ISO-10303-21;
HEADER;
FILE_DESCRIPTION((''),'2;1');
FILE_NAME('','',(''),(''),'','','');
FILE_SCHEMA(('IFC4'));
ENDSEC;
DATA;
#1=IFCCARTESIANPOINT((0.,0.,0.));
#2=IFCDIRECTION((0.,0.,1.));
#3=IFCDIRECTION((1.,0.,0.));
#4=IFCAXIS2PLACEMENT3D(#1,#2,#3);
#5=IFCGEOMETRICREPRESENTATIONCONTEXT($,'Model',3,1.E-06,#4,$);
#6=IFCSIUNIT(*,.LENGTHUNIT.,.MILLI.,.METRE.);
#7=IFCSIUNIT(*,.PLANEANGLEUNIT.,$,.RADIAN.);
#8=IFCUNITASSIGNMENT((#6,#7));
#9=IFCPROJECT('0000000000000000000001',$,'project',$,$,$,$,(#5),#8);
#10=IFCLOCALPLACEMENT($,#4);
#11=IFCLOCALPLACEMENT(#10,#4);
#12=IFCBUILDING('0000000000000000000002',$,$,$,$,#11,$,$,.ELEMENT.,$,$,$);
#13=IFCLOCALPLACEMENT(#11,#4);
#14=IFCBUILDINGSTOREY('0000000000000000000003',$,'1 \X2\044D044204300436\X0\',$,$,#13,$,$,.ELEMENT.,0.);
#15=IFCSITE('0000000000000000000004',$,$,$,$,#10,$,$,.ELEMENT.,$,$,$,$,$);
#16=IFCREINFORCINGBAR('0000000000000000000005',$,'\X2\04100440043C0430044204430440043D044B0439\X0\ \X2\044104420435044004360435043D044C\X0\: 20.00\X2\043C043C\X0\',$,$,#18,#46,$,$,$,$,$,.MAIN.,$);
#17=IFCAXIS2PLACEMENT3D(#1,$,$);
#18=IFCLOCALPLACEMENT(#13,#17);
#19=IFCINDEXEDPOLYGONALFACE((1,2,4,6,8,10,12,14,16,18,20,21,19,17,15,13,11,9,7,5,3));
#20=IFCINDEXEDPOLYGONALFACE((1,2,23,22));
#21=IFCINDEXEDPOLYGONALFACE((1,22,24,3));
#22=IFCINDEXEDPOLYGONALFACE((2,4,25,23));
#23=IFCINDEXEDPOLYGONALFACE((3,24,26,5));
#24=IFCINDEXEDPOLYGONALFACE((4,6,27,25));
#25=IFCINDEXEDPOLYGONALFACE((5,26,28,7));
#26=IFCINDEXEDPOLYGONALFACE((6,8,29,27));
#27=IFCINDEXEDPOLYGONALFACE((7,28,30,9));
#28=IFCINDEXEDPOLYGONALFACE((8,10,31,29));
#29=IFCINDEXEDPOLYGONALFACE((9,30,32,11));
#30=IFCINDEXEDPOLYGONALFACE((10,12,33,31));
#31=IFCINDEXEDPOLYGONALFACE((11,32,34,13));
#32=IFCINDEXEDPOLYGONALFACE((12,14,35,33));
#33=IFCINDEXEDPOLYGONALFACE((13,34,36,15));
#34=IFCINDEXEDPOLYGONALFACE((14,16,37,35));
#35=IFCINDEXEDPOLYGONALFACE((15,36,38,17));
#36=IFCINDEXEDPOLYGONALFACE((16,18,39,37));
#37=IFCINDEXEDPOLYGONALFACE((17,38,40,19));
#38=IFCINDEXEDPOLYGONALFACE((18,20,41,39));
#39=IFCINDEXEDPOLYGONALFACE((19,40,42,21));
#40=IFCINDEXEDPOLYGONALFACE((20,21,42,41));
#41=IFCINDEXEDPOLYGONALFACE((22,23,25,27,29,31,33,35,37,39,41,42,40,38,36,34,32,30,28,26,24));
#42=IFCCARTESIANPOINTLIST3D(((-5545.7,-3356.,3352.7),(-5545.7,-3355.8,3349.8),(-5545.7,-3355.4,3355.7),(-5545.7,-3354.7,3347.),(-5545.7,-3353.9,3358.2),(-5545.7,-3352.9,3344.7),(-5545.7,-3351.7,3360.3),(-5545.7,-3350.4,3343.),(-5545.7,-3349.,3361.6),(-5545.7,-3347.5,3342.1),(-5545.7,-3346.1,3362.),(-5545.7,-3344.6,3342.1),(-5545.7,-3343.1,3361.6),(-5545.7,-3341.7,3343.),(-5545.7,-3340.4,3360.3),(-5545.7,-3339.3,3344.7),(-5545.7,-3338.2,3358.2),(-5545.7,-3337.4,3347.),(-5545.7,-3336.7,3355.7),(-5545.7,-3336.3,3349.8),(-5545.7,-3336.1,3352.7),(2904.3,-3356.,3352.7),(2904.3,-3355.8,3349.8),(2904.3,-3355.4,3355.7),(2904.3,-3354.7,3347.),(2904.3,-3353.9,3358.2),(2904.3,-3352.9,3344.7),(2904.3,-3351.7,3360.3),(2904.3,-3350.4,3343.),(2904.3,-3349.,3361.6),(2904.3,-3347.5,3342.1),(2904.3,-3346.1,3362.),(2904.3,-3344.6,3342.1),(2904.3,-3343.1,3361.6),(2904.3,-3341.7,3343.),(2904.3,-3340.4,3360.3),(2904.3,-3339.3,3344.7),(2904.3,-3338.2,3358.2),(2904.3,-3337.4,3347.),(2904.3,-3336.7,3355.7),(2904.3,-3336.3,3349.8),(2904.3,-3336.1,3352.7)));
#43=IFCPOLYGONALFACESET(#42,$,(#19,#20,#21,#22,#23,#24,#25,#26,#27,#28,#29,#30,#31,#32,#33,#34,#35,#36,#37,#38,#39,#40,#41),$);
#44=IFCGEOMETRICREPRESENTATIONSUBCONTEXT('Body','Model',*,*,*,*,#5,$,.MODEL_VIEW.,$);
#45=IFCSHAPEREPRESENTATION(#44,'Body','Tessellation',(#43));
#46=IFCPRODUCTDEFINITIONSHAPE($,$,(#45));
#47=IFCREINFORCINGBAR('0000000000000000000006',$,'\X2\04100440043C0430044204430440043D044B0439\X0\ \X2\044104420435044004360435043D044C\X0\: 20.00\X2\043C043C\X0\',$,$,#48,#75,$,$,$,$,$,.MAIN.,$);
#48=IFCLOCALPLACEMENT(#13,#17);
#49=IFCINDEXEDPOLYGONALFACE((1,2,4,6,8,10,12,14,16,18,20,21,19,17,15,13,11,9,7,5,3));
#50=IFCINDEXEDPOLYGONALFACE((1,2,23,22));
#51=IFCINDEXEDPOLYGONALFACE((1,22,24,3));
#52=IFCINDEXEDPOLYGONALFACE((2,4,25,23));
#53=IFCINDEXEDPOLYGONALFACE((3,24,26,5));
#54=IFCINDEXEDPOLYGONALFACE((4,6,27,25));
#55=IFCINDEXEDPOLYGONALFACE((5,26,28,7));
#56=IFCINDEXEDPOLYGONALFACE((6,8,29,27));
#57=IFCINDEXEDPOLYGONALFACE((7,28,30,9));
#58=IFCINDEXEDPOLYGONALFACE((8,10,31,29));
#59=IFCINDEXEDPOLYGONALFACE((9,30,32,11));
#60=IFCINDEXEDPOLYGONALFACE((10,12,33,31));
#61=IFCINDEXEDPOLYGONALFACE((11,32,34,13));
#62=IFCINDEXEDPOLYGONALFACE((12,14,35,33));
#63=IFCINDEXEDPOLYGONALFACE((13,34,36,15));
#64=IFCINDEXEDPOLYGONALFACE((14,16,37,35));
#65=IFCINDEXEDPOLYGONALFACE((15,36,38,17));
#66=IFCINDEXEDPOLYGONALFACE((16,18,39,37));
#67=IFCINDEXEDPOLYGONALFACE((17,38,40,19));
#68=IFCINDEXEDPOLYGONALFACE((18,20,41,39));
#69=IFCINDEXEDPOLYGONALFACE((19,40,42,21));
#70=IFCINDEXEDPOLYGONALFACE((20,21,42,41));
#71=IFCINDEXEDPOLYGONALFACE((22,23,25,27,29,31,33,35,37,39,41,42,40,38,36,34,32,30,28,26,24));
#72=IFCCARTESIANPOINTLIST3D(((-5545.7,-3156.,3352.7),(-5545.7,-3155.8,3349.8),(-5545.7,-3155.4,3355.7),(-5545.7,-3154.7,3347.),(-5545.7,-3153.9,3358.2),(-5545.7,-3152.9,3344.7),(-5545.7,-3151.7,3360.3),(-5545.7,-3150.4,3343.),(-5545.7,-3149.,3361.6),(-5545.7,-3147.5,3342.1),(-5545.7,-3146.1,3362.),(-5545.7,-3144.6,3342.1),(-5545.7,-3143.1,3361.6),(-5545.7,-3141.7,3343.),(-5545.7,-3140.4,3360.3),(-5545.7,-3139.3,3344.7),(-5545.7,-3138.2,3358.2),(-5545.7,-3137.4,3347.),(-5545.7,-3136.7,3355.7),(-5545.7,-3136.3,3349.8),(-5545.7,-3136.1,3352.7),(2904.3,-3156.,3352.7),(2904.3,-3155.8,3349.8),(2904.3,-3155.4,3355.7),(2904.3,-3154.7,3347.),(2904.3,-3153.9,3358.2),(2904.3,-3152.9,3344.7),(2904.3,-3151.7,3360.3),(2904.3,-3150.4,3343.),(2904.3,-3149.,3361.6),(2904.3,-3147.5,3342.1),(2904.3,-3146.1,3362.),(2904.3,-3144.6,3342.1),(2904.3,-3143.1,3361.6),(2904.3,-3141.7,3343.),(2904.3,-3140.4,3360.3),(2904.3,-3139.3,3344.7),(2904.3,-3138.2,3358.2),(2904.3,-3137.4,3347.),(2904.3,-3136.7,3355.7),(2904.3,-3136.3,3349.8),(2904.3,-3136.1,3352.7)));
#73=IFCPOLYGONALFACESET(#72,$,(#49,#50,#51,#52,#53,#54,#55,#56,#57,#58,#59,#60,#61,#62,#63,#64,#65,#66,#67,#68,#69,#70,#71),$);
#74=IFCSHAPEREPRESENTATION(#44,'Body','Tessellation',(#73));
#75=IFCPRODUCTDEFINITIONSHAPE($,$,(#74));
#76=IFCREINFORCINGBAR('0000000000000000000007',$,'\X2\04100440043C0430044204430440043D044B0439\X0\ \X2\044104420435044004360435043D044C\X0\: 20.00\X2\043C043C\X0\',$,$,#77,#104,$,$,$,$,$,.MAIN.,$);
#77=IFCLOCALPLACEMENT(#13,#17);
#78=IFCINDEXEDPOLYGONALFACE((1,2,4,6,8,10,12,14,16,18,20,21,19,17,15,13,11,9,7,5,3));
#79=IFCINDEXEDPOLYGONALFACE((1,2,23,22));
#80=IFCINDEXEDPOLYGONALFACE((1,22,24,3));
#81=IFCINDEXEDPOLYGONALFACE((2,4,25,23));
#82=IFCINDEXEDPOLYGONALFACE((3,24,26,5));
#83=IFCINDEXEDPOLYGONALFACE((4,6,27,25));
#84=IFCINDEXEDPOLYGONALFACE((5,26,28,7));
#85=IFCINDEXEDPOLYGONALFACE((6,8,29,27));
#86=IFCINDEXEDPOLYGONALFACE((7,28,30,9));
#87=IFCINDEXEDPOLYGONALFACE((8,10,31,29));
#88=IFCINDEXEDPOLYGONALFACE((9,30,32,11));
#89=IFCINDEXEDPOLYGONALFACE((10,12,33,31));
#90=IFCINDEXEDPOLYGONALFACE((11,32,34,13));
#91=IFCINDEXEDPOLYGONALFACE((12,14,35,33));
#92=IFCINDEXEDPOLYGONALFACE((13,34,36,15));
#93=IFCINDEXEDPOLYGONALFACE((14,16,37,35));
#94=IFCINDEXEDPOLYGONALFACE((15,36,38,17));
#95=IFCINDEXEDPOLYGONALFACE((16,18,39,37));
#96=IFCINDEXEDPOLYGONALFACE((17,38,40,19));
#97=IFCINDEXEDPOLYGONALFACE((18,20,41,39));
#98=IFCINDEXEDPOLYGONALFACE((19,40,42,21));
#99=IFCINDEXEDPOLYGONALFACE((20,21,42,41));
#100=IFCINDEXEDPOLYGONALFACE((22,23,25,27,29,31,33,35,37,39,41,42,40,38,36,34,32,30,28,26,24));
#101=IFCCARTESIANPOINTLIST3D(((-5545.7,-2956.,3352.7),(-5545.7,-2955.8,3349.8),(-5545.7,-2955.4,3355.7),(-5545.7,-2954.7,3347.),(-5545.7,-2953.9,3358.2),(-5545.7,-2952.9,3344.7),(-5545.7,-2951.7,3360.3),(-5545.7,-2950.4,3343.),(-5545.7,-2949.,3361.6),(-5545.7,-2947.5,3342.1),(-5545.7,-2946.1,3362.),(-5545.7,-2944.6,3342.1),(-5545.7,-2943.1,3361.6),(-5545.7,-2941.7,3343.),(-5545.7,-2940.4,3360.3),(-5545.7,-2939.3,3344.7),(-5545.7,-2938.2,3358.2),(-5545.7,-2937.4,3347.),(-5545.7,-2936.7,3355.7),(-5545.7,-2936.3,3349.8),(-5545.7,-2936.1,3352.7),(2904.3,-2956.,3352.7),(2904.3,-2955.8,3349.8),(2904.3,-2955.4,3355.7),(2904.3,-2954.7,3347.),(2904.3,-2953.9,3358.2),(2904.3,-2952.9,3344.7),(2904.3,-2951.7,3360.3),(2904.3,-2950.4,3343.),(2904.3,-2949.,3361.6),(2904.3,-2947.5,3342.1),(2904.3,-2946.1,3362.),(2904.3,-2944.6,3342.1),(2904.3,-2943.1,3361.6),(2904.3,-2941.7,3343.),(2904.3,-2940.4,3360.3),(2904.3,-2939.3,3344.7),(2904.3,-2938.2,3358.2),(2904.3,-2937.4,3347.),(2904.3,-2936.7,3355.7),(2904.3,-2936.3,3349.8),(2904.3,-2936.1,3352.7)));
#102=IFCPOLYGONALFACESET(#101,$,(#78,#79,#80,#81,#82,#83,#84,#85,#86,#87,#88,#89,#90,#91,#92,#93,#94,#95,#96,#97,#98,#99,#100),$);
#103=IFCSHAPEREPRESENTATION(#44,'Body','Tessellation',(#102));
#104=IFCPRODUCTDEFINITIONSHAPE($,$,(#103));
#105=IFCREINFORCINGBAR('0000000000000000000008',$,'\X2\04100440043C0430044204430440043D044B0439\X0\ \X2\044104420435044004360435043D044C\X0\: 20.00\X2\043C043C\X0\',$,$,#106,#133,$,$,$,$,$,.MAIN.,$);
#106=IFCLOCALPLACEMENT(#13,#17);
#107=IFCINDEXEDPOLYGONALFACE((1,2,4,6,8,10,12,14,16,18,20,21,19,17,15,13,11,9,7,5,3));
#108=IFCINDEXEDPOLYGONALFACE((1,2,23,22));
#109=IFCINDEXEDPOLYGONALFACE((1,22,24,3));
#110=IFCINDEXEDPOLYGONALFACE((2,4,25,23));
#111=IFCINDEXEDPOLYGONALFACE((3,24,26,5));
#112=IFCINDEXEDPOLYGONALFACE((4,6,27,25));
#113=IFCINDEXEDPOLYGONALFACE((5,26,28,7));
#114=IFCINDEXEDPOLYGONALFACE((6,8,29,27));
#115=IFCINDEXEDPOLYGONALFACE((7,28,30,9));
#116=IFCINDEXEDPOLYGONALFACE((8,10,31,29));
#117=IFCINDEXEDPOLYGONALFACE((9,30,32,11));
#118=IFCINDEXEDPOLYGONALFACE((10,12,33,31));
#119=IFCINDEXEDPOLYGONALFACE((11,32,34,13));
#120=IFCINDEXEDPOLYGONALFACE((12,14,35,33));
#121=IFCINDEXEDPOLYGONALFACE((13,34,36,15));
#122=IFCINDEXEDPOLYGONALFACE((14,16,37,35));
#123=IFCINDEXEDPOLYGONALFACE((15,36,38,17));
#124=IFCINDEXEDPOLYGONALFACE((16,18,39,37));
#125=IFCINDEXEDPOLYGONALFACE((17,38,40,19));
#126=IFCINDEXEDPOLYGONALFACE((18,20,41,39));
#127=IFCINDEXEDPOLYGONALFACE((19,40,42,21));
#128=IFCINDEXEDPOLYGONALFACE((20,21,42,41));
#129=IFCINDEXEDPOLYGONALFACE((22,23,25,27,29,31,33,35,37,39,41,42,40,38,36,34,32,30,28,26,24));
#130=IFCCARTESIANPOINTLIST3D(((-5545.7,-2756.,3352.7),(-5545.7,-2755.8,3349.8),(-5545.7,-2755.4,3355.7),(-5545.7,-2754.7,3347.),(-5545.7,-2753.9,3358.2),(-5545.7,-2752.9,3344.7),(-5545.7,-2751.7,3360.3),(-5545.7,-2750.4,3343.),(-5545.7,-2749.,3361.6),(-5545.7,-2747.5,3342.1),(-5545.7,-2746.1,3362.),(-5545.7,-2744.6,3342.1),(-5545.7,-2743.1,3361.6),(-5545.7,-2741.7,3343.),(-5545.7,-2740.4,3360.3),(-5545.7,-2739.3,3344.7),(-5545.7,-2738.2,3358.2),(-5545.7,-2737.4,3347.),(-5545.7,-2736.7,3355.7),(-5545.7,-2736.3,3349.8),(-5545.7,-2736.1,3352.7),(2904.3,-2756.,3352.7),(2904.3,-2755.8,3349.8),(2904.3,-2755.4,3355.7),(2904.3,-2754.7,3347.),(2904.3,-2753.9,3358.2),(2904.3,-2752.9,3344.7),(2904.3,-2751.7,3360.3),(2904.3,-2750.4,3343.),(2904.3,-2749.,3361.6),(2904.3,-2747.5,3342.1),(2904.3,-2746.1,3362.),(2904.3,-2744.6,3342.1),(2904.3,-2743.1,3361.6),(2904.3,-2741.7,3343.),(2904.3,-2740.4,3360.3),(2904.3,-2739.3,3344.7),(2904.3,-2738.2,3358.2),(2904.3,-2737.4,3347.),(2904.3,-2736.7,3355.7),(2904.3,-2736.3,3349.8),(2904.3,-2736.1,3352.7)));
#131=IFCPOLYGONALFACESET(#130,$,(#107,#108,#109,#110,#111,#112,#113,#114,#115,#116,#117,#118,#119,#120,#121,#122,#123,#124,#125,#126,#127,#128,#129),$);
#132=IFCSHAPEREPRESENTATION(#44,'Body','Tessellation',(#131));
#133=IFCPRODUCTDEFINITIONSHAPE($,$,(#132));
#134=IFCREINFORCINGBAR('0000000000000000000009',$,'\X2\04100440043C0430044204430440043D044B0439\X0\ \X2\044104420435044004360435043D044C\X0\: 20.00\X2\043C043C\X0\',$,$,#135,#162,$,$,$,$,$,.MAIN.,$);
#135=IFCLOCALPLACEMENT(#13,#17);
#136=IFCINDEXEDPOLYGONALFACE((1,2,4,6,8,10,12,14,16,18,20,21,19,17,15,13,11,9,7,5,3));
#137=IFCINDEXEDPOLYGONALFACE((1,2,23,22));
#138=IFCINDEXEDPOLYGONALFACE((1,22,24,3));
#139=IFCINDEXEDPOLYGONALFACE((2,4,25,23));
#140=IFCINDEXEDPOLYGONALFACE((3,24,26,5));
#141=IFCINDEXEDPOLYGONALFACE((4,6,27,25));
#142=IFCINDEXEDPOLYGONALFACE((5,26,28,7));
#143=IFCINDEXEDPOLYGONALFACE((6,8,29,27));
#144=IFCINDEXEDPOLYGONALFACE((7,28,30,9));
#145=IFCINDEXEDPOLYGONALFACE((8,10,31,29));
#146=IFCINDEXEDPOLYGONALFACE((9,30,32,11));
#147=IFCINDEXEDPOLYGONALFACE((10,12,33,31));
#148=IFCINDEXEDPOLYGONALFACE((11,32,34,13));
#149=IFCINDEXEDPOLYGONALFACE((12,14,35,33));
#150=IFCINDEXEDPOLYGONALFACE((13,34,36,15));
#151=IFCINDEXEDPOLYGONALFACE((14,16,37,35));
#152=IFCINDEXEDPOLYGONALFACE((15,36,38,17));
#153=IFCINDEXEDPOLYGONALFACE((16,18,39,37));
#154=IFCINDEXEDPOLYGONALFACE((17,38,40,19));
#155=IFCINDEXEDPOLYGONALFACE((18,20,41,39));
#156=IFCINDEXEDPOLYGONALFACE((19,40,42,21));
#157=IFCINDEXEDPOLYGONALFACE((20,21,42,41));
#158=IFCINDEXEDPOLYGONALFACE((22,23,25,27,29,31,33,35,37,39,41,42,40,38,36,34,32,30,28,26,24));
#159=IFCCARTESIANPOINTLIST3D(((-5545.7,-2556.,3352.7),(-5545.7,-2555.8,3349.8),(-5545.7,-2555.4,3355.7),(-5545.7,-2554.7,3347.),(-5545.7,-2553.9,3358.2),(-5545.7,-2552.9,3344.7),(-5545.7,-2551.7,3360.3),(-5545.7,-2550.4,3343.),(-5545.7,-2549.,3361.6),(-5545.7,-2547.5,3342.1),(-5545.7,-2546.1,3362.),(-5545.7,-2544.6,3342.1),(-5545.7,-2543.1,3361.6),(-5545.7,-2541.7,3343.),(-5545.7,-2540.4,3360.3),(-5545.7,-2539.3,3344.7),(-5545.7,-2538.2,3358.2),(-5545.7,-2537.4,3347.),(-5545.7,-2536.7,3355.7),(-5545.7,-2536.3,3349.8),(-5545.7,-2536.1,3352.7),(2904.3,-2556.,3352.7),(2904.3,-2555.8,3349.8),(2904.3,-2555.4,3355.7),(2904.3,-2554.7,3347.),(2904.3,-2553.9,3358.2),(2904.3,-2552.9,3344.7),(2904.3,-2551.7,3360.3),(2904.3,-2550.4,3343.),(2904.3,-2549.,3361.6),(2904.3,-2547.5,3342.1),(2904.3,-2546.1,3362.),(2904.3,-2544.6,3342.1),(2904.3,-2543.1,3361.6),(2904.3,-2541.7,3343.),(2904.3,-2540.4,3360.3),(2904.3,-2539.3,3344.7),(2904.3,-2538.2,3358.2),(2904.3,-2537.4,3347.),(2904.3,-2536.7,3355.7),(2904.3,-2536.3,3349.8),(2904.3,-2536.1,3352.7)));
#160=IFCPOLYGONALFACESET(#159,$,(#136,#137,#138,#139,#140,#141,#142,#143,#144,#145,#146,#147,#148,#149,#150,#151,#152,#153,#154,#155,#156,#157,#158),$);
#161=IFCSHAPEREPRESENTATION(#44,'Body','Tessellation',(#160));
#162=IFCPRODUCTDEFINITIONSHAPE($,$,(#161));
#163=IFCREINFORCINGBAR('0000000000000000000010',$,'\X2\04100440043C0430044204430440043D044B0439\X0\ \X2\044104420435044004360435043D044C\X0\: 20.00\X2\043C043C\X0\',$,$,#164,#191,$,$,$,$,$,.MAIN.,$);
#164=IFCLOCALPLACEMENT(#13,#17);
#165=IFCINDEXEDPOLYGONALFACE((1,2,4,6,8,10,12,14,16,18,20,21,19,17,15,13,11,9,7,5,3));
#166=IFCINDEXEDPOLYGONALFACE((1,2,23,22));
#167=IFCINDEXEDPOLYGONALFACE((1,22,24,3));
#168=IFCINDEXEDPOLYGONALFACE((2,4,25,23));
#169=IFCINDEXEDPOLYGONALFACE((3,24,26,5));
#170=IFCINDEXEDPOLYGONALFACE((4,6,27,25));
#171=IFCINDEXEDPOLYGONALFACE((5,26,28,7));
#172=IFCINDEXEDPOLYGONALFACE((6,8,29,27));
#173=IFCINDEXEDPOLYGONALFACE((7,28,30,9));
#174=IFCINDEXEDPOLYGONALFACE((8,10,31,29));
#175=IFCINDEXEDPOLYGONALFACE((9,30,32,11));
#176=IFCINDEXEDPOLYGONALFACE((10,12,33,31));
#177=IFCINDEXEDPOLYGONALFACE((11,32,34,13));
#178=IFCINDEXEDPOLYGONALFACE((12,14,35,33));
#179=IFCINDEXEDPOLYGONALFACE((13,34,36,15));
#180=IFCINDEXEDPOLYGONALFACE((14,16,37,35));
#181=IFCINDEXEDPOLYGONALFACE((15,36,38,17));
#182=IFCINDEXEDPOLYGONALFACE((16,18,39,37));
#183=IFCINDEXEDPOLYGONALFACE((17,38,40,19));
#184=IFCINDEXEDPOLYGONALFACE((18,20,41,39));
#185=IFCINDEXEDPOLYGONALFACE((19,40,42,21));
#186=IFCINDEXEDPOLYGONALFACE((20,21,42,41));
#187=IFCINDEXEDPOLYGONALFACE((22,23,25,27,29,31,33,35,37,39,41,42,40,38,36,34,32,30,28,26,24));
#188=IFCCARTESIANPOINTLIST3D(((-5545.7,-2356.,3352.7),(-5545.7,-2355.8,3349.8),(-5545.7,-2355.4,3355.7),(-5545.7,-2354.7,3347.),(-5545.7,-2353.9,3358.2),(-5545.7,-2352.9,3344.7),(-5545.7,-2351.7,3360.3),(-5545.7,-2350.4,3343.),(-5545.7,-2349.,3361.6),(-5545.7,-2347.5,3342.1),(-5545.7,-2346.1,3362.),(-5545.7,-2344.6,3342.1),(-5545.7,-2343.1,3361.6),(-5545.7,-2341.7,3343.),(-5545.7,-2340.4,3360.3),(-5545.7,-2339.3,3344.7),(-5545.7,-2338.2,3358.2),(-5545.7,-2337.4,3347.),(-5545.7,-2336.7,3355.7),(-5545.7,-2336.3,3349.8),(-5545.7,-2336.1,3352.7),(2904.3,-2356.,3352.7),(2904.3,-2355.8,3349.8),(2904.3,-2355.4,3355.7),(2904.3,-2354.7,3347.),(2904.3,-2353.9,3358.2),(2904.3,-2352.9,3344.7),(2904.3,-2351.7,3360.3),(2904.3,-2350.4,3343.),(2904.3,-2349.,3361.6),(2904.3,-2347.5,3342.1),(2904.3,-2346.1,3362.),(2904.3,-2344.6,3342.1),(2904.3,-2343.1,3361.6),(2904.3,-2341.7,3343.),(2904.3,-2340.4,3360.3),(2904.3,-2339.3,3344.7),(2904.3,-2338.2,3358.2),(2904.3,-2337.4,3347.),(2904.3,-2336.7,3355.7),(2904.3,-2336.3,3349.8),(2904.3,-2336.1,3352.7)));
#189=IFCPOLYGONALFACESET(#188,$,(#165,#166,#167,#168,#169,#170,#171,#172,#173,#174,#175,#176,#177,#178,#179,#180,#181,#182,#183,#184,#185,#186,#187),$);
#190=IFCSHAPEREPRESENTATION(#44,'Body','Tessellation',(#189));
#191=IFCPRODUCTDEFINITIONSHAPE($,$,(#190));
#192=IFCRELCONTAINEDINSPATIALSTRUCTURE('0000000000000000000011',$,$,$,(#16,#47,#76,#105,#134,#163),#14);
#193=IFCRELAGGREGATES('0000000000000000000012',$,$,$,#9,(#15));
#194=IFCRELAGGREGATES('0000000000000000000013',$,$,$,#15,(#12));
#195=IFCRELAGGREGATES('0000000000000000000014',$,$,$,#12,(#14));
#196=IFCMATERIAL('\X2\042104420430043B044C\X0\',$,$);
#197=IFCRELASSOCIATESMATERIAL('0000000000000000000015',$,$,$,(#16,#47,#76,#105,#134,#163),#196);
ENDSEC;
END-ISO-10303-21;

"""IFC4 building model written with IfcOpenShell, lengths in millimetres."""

from ifc_helpers import new_model, entity, si_unit, origin_with_axes, place, context, subcontext, project, spatial, source, transform, mapped, material, element, save


model = new_model("IFC4")

# Units and contexts
model_context = context("Model", 3, precision=1e-06, world=origin_with_axes())
body_context = subcontext(model_context, "Body", "Model", "MODEL_VIEW")
ifc_project = project(units=[si_unit("LENGTHUNIT", "METRE", prefix="MILLI"), si_unit("PLANEANGLEUNIT", "RADIAN")], contexts=[model_context])

# Site, building, storey
site_placement = place(None, origin_with_axes())
site = spatial("IfcSite", under=ifc_project, at=site_placement, CompositionType="ELEMENT")
building_placement = place(site_placement, origin_with_axes())
building = spatial("IfcBuilding", under=site, at=building_placement, CompositionType="ELEMENT")
storey_placement = place(building_placement, origin_with_axes())
storey = spatial("IfcBuildingStorey", under=building, at=storey_placement, Name="1 этаж", CompositionType="ELEMENT", Elevation=0.0)

# Shared definitions
ifc_material_1 = material(Name="Сталь")

# Reinforcing bars
shared_shape_1 = source(origin_with_axes(), body_context, "Body", "AdvancedSweptSolid", [
    entity("IfcSweptDiskSolid", entity("IfcIndexedPolyCurve", entity("IfcCartesianPointList3D", [[0.0, 0.0, 0.0], [8450.0, 0.0, 0.0]]), [entity("IfcLineIndex", [1, 2])]), 10.0),
])
reinforcing_bar_1_placement = place(storey_placement, origin_with_axes())
element("IfcReinforcingBar", 1, at=reinforcing_bar_1_placement, inside=storey, material=ifc_material_1, Name="Арматурный стержень: 20.00мм", PredefinedType="MAIN", context=body_context, shape_type="MappedRepresentation", body=[
    mapped(shared_shape_1, transform((-5545.7, -3346.1, 3352.0), x_axis=(1.0, 0.0, 0.0), y_axis=(0.0, 1.0, 0.0), z_axis=(0.0, 0.0, 1.0), scale=1.0)),
])
reinforcing_bar_2_placement = place(storey_placement, origin_with_axes())
element("IfcReinforcingBar", 2, at=reinforcing_bar_2_placement, inside=storey, material=ifc_material_1, Name="Арматурный стержень: 20.00мм", PredefinedType="MAIN", context=body_context, shape_type="MappedRepresentation", body=[
    mapped(shared_shape_1, transform((-5545.7, -3146.1, 3352.0), x_axis=(1.0, 0.0, 0.0), y_axis=(0.0, 1.0, 0.0), z_axis=(0.0, 0.0, 1.0), scale=1.0)),
])
reinforcing_bar_3_placement = place(storey_placement, origin_with_axes())
element("IfcReinforcingBar", 3, at=reinforcing_bar_3_placement, inside=storey, material=ifc_material_1, Name="Арматурный стержень: 20.00мм", PredefinedType="MAIN", context=body_context, shape_type="MappedRepresentation", body=[
    mapped(shared_shape_1, transform((-5545.7, -2946.1, 3352.0), x_axis=(1.0, 0.0, 0.0), y_axis=(0.0, 1.0, 0.0), z_axis=(0.0, 0.0, 1.0), scale=1.0)),
])
reinforcing_bar_4_placement = place(storey_placement, origin_with_axes())
element("IfcReinforcingBar", 4, at=reinforcing_bar_4_placement, inside=storey, material=ifc_material_1, Name="Арматурный стержень: 20.00мм", PredefinedType="MAIN", context=body_context, shape_type="MappedRepresentation", body=[
    mapped(shared_shape_1, transform((-5545.7, -2746.1, 3352.0), x_axis=(1.0, 0.0, 0.0), y_axis=(0.0, 1.0, 0.0), z_axis=(0.0, 0.0, 1.0), scale=1.0)),
])
reinforcing_bar_5_placement = place(storey_placement, origin_with_axes())
element("IfcReinforcingBar", 5, at=reinforcing_bar_5_placement, inside=storey, material=ifc_material_1, Name="Арматурный стержень: 20.00мм", PredefinedType="MAIN", context=body_context, shape_type="MappedRepresentation", body=[
    mapped(shared_shape_1, transform((-5545.7, -2546.1, 3352.0), x_axis=(1.0, 0.0, 0.0), y_axis=(0.0, 1.0, 0.0), z_axis=(0.0, 0.0, 1.0), scale=1.0)),
])
reinforcing_bar_6_placement = place(storey_placement, origin_with_axes())
element("IfcReinforcingBar", 6, at=reinforcing_bar_6_placement, inside=storey, material=ifc_material_1, Name="Арматурный стержень: 20.00мм", PredefinedType="MAIN", context=body_context, shape_type="MappedRepresentation", body=[
    mapped(shared_shape_1, transform((-5545.7, -2346.1, 3352.0), x_axis=(1.0, 0.0, 0.0), y_axis=(0.0, 1.0, 0.0), z_axis=(0.0, 0.0, 1.0), scale=1.0)),
])

save(model, "model.ifc")
